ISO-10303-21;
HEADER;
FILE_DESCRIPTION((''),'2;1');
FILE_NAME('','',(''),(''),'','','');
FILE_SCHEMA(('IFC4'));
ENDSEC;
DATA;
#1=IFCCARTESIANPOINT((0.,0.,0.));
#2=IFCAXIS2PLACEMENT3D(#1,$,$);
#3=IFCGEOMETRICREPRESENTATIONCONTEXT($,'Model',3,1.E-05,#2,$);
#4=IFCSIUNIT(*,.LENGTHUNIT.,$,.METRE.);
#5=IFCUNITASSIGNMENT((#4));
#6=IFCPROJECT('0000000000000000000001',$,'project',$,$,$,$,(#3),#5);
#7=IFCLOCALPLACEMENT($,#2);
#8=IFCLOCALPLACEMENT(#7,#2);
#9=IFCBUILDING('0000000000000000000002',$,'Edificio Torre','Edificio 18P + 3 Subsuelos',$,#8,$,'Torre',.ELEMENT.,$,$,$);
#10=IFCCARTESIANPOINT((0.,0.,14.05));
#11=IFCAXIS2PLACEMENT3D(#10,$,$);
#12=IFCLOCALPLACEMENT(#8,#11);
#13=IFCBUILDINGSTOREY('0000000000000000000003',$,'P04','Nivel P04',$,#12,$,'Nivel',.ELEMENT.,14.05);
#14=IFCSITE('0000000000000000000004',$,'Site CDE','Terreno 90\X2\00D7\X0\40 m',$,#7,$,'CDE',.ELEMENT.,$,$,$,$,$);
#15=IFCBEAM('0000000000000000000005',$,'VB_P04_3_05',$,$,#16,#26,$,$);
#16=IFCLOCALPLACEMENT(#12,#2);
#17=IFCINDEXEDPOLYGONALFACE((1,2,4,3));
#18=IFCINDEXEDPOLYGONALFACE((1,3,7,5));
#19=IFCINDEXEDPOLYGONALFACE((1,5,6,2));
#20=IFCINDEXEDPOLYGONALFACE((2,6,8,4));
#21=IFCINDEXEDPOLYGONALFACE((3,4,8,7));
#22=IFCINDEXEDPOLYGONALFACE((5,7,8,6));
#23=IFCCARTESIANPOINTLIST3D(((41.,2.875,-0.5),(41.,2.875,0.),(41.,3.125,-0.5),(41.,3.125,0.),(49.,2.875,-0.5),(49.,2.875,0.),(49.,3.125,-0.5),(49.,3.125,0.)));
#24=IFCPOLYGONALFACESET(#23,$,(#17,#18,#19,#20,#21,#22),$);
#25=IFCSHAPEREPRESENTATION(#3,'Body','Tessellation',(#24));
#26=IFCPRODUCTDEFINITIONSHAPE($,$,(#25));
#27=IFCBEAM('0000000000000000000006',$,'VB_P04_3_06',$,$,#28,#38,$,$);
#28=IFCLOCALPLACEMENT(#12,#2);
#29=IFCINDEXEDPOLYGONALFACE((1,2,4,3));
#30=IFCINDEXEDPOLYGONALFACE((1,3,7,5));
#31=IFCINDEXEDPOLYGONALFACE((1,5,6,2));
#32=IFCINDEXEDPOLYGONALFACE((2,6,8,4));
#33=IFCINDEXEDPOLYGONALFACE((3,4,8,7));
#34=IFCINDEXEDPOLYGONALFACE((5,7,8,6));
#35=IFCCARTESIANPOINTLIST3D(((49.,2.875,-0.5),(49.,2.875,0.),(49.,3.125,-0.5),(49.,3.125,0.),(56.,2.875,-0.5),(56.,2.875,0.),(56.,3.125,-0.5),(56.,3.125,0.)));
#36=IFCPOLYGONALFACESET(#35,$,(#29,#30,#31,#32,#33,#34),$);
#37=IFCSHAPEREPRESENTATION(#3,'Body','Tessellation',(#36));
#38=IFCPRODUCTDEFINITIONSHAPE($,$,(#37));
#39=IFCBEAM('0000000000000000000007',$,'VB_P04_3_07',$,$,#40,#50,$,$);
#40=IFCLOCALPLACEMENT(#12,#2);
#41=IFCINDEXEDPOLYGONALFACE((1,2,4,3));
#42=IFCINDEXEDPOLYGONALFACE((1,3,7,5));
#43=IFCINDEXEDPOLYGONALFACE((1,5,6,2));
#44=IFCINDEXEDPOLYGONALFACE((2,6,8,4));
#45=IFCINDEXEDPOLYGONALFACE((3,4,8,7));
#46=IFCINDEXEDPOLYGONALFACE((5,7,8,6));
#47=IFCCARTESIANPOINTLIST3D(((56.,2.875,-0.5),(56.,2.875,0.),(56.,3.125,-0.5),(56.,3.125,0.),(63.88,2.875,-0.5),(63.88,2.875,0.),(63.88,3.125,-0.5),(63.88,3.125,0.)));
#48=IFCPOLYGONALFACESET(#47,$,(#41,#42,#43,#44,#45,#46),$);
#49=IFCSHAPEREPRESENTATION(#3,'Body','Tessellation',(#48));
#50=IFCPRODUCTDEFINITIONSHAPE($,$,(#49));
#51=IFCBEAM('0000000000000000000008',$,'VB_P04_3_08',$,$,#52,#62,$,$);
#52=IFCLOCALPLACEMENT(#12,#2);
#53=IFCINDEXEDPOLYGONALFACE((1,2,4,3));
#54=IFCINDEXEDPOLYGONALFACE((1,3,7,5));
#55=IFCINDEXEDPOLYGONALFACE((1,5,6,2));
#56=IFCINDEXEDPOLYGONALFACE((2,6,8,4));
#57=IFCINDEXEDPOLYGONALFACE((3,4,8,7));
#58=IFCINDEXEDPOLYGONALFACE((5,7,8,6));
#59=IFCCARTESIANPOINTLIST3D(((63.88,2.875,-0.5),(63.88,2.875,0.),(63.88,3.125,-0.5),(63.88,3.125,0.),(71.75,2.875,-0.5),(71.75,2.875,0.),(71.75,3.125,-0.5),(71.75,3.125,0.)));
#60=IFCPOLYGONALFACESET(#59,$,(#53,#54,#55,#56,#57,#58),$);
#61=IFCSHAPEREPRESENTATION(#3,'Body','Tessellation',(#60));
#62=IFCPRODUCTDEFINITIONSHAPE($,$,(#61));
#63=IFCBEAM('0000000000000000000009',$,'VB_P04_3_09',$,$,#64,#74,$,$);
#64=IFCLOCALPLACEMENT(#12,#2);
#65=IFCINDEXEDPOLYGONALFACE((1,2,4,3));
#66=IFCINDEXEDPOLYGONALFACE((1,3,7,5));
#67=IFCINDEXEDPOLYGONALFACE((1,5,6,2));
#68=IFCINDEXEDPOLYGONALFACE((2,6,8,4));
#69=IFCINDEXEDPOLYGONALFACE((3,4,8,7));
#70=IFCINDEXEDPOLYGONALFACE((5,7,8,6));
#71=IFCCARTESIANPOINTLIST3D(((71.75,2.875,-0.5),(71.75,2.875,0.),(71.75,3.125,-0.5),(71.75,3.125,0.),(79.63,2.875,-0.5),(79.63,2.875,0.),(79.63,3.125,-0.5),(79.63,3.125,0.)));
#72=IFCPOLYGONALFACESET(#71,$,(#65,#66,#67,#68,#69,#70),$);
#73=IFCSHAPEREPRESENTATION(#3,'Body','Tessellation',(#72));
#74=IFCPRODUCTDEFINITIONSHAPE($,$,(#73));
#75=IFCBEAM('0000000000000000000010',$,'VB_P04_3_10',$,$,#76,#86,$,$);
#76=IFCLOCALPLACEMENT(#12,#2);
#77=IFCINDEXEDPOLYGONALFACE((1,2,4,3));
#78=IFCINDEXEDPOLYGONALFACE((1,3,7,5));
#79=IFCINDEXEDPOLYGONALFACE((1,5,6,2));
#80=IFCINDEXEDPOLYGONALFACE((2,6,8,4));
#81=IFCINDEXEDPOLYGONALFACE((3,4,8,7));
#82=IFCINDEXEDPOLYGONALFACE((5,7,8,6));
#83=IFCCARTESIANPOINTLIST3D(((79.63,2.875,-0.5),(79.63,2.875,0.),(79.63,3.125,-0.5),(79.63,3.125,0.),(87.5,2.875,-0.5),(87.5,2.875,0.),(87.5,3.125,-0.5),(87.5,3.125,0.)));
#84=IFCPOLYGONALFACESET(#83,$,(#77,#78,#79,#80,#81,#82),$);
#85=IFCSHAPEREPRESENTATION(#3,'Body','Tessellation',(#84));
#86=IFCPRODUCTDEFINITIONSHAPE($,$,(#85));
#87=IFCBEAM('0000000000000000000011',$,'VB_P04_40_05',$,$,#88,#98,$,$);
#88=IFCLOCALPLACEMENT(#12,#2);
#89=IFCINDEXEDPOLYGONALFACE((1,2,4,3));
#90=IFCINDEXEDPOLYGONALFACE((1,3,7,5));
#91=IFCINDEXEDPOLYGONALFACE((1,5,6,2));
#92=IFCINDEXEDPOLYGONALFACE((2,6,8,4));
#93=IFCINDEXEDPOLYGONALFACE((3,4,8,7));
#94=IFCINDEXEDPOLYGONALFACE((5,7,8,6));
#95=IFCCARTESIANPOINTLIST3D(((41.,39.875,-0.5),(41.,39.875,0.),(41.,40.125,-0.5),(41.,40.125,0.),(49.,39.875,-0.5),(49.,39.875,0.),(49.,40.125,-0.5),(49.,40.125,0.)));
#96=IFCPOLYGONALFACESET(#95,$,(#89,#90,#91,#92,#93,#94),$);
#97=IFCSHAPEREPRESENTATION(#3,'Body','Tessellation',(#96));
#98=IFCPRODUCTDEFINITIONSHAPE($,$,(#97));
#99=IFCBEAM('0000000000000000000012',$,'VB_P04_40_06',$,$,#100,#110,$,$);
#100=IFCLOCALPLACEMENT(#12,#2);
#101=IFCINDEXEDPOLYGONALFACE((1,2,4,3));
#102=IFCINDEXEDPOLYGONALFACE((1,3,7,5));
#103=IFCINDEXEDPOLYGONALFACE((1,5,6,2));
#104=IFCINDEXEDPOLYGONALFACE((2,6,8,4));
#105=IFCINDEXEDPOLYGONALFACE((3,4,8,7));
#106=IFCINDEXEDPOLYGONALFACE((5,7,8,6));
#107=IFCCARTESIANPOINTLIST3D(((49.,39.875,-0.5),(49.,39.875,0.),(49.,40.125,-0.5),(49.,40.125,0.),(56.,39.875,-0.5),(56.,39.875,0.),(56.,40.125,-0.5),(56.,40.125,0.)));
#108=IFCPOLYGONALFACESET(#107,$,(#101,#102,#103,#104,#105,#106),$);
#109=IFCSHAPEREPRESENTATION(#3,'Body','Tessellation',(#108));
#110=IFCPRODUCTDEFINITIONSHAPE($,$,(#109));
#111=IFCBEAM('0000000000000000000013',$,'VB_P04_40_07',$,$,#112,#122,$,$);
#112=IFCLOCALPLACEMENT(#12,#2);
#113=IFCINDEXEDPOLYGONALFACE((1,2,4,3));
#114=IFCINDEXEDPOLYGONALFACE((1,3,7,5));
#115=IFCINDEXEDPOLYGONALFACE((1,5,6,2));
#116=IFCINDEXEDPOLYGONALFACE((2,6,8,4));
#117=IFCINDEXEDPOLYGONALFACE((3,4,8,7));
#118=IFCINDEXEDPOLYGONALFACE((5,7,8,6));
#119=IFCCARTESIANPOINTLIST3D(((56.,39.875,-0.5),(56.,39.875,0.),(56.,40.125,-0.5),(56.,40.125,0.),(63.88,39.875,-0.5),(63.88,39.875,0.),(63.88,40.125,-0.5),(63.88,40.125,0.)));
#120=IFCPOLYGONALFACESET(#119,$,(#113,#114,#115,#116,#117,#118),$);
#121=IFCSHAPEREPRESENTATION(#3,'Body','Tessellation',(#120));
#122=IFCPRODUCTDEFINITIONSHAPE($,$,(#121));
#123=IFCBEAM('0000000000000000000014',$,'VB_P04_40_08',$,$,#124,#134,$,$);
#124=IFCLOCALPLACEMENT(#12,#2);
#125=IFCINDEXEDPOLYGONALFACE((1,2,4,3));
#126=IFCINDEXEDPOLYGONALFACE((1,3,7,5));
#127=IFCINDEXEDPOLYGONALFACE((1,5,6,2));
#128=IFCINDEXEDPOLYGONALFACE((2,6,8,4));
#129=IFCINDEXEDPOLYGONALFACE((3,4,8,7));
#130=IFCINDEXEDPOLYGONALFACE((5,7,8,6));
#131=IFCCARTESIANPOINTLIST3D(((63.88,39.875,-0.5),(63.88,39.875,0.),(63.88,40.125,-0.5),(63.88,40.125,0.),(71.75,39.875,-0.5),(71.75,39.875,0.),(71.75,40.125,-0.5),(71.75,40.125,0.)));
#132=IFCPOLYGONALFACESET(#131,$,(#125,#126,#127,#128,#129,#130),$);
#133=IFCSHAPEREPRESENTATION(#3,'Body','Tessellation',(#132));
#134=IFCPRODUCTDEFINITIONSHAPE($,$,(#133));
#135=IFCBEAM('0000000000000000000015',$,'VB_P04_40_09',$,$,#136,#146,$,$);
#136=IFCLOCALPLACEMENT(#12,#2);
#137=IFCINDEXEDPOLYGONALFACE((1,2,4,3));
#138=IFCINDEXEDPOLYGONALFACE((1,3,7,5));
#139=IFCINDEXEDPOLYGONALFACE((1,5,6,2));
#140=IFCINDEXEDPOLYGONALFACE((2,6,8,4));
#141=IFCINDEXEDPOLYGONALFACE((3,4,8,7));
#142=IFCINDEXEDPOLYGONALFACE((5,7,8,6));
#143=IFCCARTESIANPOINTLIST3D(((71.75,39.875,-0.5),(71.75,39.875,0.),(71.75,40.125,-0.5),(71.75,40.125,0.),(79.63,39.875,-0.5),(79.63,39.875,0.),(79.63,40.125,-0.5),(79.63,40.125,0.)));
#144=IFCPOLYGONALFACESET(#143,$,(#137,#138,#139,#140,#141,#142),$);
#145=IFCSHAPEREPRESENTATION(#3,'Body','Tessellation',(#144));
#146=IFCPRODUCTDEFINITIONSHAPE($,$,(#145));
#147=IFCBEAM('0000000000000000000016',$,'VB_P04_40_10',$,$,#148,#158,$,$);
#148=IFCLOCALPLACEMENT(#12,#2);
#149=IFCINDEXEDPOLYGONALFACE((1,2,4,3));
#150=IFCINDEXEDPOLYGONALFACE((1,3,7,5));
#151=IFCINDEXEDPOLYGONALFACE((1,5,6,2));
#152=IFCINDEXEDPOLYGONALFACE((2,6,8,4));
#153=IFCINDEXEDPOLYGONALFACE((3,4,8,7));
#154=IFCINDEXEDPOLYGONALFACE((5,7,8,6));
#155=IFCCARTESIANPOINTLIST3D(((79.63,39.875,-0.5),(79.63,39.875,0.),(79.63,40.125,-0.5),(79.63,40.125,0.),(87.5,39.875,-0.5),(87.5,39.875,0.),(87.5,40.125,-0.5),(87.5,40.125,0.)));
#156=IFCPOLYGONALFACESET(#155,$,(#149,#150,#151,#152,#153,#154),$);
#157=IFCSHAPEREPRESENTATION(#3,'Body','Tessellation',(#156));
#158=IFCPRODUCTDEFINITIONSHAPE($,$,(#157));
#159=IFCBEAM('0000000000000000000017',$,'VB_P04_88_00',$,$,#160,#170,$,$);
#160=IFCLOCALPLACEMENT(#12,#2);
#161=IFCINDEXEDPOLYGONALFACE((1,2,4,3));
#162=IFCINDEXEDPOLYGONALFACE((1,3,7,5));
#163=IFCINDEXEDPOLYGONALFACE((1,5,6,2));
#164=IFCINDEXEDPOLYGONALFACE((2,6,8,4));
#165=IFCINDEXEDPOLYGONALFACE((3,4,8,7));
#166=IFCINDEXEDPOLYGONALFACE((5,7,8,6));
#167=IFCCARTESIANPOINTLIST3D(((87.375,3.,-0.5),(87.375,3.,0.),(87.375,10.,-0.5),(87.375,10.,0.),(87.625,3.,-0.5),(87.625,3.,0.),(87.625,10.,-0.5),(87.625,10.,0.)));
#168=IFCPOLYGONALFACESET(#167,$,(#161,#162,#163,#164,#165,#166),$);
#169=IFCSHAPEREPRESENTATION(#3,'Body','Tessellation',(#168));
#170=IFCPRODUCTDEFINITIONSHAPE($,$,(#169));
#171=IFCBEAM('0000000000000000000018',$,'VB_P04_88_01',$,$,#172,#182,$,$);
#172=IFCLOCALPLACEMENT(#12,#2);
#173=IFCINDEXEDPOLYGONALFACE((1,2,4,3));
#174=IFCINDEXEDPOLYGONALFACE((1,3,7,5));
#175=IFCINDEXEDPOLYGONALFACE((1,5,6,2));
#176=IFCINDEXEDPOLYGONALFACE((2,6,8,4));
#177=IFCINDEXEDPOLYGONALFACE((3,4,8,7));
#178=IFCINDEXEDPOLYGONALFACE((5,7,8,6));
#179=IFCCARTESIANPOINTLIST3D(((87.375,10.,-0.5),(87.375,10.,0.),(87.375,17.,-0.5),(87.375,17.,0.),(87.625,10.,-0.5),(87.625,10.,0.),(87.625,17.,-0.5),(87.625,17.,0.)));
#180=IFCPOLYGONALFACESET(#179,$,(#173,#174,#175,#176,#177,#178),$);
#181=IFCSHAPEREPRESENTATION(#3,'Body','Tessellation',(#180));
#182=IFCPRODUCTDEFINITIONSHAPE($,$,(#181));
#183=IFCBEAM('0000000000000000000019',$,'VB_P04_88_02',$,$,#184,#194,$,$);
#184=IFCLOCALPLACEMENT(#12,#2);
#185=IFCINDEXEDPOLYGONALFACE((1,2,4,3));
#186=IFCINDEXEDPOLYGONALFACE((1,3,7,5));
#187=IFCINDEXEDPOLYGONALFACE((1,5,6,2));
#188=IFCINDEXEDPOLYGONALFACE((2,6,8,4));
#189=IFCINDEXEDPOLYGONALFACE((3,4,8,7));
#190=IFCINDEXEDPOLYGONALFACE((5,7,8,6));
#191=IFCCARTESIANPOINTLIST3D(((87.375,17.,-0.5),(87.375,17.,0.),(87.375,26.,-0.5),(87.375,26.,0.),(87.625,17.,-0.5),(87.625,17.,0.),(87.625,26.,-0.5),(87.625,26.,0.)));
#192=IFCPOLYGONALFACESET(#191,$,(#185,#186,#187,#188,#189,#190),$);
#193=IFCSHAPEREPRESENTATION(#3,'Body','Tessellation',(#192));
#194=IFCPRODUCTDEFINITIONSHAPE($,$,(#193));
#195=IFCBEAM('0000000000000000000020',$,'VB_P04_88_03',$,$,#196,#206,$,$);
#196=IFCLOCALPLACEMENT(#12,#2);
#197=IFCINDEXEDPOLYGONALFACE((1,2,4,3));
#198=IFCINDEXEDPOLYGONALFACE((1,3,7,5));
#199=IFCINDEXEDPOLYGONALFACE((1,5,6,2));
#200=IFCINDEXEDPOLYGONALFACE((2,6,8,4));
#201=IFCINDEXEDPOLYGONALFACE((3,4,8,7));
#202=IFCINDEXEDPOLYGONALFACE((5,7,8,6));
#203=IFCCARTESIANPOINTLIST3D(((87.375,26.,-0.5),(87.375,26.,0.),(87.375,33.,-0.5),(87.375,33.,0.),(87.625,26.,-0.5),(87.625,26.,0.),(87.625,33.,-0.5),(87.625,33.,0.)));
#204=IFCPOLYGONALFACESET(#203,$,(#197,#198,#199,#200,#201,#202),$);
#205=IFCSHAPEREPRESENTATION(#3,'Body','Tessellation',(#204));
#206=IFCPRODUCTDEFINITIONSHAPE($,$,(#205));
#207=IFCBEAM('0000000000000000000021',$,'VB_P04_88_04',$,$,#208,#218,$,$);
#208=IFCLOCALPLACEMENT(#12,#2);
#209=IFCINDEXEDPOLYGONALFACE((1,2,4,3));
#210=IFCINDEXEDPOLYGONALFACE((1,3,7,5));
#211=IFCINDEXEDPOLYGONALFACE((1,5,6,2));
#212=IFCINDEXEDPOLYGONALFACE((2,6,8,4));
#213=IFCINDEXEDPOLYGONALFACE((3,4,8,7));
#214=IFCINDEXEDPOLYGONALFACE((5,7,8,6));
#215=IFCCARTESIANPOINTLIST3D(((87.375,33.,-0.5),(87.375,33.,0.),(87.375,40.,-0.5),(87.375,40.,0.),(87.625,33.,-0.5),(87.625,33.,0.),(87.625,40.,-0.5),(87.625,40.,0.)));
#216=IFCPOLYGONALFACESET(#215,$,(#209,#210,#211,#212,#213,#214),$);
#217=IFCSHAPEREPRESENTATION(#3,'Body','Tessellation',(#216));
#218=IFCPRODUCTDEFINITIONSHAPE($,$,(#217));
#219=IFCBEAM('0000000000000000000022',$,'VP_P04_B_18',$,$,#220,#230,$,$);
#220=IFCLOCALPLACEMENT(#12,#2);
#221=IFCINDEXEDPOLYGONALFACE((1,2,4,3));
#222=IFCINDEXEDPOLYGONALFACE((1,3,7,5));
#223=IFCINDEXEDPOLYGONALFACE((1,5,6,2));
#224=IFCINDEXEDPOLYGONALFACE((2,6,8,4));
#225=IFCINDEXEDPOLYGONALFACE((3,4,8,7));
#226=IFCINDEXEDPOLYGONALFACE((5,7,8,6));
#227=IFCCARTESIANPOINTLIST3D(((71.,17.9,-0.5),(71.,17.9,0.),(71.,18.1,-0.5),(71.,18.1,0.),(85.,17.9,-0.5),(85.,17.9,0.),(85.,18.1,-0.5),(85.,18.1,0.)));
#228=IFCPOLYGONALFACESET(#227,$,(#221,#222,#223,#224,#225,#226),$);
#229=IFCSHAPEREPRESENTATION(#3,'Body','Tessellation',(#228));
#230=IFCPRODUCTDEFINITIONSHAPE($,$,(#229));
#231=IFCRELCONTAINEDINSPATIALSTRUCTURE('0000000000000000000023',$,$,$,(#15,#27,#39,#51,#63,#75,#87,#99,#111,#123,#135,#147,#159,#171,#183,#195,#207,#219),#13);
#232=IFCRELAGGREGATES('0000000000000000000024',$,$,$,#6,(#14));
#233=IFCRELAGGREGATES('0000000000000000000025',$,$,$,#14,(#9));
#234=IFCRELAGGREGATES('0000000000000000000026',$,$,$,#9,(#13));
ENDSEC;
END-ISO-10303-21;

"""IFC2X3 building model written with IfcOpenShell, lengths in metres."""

from ifc_helpers import new_model, si_unit, frame, origin, origin_2d, place, context, project, spatial, rectangle, extrude, element, save


model = new_model("IFC2X3")

# Units and contexts
model_context = context("Model", 3, precision=1e-05, world=origin())
ifc_project = project(units=[si_unit("LENGTHUNIT", "METRE")], contexts=[model_context])

# Site, building, storey
site_placement = place(None, origin())
site = spatial("IfcSite", under=ifc_project, at=site_placement, Name="Site CDE", Description="Terreno 90×40 m", LongName="CDE", CompositionType="ELEMENT")
building_placement = place(site_placement, origin())
building = spatial("IfcBuilding", under=site, at=building_placement, Name="Edificio Torre", Description="Edificio 18P + 3 Subsuelos", LongName="Torre", CompositionType="ELEMENT")
storey_placement = place(building_placement, frame((0.0, 0.0, 14.05)))
storey = spatial("IfcBuildingStorey", under=building, at=storey_placement, Name="P04", Description="Nivel P04", LongName="Nivel", CompositionType="ELEMENT", Elevation=14.05)

# Beams
beam_1_placement = place(storey_placement, frame((45.0, 3.0, -0.5)))
element("IfcBeam", 1, at=beam_1_placement, inside=storey, Name="VB_P04_3_05", context=model_context, shape_type="SweptSolid", body=[
    extrude(rectangle(XDim=8.0, YDim=0.25, at=origin_2d()), origin(), (0.0, 0.0, 1.0), 0.5),
])
beam_2_placement = place(storey_placement, frame((52.5, 3.0, -0.5)))
element("IfcBeam", 2, at=beam_2_placement, inside=storey, Name="VB_P04_3_06", context=model_context, shape_type="SweptSolid", body=[
    extrude(rectangle(XDim=7.0, YDim=0.25, at=origin_2d()), origin(), (0.0, 0.0, 1.0), 0.5),
])
beam_3_placement = place(storey_placement, frame((59.94, 3.0, -0.5)))
element("IfcBeam", 3, at=beam_3_placement, inside=storey, Name="VB_P04_3_07", context=model_context, shape_type="SweptSolid", body=[
    extrude(rectangle(XDim=7.88, YDim=0.25, at=origin_2d()), origin(), (0.0, 0.0, 1.0), 0.5),
])
beam_4_placement = place(storey_placement, frame((67.815, 3.0, -0.5)))
element("IfcBeam", 4, at=beam_4_placement, inside=storey, Name="VB_P04_3_08", context=model_context, shape_type="SweptSolid", body=[
    extrude(rectangle(XDim=7.87, YDim=0.25, at=origin_2d()), origin(), (0.0, 0.0, 1.0), 0.5),
])
beam_5_placement = place(storey_placement, frame((75.69, 3.0, -0.5)))
element("IfcBeam", 5, at=beam_5_placement, inside=storey, Name="VB_P04_3_09", context=model_context, shape_type="SweptSolid", body=[
    extrude(rectangle(XDim=7.88, YDim=0.25, at=origin_2d()), origin(), (0.0, 0.0, 1.0), 0.5),
])
beam_6_placement = place(storey_placement, frame((83.565, 3.0, -0.5)))
element("IfcBeam", 6, at=beam_6_placement, inside=storey, Name="VB_P04_3_10", context=model_context, shape_type="SweptSolid", body=[
    extrude(rectangle(XDim=7.87, YDim=0.25, at=origin_2d()), origin(), (0.0, 0.0, 1.0), 0.5),
])
beam_7_placement = place(storey_placement, frame((45.0, 40.0, -0.5)))
element("IfcBeam", 7, at=beam_7_placement, inside=storey, Name="VB_P04_40_05", context=model_context, shape_type="SweptSolid", body=[
    extrude(rectangle(XDim=8.0, YDim=0.25, at=origin_2d()), origin(), (0.0, 0.0, 1.0), 0.5),
])
beam_8_placement = place(storey_placement, frame((52.5, 40.0, -0.5)))
element("IfcBeam", 8, at=beam_8_placement, inside=storey, Name="VB_P04_40_06", context=model_context, shape_type="SweptSolid", body=[
    extrude(rectangle(XDim=7.0, YDim=0.25, at=origin_2d()), origin(), (0.0, 0.0, 1.0), 0.5),
])
beam_9_placement = place(storey_placement, frame((59.94, 40.0, -0.5)))
element("IfcBeam", 9, at=beam_9_placement, inside=storey, Name="VB_P04_40_07", context=model_context, shape_type="SweptSolid", body=[
    extrude(rectangle(XDim=7.88, YDim=0.25, at=origin_2d()), origin(), (0.0, 0.0, 1.0), 0.5),
])
beam_10_placement = place(storey_placement, frame((67.815, 40.0, -0.5)))
element("IfcBeam", 10, at=beam_10_placement, inside=storey, Name="VB_P04_40_08", context=model_context, shape_type="SweptSolid", body=[
    extrude(rectangle(XDim=7.87, YDim=0.25, at=origin_2d()), origin(), (0.0, 0.0, 1.0), 0.5),
])
beam_11_placement = place(storey_placement, frame((75.69, 40.0, -0.5)))
element("IfcBeam", 11, at=beam_11_placement, inside=storey, Name="VB_P04_40_09", context=model_context, shape_type="SweptSolid", body=[
    extrude(rectangle(XDim=7.88, YDim=0.25, at=origin_2d()), origin(), (0.0, 0.0, 1.0), 0.5),
])
beam_12_placement = place(storey_placement, frame((83.565, 40.0, -0.5)))
element("IfcBeam", 12, at=beam_12_placement, inside=storey, Name="VB_P04_40_10", context=model_context, shape_type="SweptSolid", body=[
    extrude(rectangle(XDim=7.87, YDim=0.25, at=origin_2d()), origin(), (0.0, 0.0, 1.0), 0.5),
])
for number, where, name in (
    (13, (87.5, 6.5, -0.5), "VB_P04_88_00"),
    (14, (87.5, 13.5, -0.5), "VB_P04_88_01"),
):
    element("IfcBeam", number, at=place(storey_placement, frame(where)), inside=storey, Name=name, context=model_context, shape_type="SweptSolid", body=[
        extrude(rectangle(XDim=0.25, YDim=7.0, at=origin_2d()), origin(), (0.0, 0.0, 1.0), 0.5),
    ])
beam_13_placement = place(storey_placement, frame((87.5, 21.5, -0.5)))
element("IfcBeam", 15, at=beam_13_placement, inside=storey, Name="VB_P04_88_02", context=model_context, shape_type="SweptSolid", body=[
    extrude(rectangle(XDim=0.25, YDim=9.0, at=origin_2d()), origin(), (0.0, 0.0, 1.0), 0.5),
])
for number, where, name in (
    (16, (87.5, 29.5, -0.5), "VB_P04_88_03"),
    (17, (87.5, 36.5, -0.5), "VB_P04_88_04"),
):
    element("IfcBeam", number, at=place(storey_placement, frame(where)), inside=storey, Name=name, context=model_context, shape_type="SweptSolid", body=[
        extrude(rectangle(XDim=0.25, YDim=7.0, at=origin_2d()), origin(), (0.0, 0.0, 1.0), 0.5),
    ])
for number, where, name in (
    (18, (78.0, 18.0, -0.5), "VP_P04_B_18"),
):
    element("IfcBeam", number, at=place(storey_placement, frame(where)), inside=storey, Name=name, context=model_context, shape_type="SweptSolid", body=[
        extrude(rectangle(XDim=14.0, YDim=0.2, at=origin_2d()), origin(), (0.0, 0.0, 1.0), 0.5),
    ])

save(model, "model.ifc")
